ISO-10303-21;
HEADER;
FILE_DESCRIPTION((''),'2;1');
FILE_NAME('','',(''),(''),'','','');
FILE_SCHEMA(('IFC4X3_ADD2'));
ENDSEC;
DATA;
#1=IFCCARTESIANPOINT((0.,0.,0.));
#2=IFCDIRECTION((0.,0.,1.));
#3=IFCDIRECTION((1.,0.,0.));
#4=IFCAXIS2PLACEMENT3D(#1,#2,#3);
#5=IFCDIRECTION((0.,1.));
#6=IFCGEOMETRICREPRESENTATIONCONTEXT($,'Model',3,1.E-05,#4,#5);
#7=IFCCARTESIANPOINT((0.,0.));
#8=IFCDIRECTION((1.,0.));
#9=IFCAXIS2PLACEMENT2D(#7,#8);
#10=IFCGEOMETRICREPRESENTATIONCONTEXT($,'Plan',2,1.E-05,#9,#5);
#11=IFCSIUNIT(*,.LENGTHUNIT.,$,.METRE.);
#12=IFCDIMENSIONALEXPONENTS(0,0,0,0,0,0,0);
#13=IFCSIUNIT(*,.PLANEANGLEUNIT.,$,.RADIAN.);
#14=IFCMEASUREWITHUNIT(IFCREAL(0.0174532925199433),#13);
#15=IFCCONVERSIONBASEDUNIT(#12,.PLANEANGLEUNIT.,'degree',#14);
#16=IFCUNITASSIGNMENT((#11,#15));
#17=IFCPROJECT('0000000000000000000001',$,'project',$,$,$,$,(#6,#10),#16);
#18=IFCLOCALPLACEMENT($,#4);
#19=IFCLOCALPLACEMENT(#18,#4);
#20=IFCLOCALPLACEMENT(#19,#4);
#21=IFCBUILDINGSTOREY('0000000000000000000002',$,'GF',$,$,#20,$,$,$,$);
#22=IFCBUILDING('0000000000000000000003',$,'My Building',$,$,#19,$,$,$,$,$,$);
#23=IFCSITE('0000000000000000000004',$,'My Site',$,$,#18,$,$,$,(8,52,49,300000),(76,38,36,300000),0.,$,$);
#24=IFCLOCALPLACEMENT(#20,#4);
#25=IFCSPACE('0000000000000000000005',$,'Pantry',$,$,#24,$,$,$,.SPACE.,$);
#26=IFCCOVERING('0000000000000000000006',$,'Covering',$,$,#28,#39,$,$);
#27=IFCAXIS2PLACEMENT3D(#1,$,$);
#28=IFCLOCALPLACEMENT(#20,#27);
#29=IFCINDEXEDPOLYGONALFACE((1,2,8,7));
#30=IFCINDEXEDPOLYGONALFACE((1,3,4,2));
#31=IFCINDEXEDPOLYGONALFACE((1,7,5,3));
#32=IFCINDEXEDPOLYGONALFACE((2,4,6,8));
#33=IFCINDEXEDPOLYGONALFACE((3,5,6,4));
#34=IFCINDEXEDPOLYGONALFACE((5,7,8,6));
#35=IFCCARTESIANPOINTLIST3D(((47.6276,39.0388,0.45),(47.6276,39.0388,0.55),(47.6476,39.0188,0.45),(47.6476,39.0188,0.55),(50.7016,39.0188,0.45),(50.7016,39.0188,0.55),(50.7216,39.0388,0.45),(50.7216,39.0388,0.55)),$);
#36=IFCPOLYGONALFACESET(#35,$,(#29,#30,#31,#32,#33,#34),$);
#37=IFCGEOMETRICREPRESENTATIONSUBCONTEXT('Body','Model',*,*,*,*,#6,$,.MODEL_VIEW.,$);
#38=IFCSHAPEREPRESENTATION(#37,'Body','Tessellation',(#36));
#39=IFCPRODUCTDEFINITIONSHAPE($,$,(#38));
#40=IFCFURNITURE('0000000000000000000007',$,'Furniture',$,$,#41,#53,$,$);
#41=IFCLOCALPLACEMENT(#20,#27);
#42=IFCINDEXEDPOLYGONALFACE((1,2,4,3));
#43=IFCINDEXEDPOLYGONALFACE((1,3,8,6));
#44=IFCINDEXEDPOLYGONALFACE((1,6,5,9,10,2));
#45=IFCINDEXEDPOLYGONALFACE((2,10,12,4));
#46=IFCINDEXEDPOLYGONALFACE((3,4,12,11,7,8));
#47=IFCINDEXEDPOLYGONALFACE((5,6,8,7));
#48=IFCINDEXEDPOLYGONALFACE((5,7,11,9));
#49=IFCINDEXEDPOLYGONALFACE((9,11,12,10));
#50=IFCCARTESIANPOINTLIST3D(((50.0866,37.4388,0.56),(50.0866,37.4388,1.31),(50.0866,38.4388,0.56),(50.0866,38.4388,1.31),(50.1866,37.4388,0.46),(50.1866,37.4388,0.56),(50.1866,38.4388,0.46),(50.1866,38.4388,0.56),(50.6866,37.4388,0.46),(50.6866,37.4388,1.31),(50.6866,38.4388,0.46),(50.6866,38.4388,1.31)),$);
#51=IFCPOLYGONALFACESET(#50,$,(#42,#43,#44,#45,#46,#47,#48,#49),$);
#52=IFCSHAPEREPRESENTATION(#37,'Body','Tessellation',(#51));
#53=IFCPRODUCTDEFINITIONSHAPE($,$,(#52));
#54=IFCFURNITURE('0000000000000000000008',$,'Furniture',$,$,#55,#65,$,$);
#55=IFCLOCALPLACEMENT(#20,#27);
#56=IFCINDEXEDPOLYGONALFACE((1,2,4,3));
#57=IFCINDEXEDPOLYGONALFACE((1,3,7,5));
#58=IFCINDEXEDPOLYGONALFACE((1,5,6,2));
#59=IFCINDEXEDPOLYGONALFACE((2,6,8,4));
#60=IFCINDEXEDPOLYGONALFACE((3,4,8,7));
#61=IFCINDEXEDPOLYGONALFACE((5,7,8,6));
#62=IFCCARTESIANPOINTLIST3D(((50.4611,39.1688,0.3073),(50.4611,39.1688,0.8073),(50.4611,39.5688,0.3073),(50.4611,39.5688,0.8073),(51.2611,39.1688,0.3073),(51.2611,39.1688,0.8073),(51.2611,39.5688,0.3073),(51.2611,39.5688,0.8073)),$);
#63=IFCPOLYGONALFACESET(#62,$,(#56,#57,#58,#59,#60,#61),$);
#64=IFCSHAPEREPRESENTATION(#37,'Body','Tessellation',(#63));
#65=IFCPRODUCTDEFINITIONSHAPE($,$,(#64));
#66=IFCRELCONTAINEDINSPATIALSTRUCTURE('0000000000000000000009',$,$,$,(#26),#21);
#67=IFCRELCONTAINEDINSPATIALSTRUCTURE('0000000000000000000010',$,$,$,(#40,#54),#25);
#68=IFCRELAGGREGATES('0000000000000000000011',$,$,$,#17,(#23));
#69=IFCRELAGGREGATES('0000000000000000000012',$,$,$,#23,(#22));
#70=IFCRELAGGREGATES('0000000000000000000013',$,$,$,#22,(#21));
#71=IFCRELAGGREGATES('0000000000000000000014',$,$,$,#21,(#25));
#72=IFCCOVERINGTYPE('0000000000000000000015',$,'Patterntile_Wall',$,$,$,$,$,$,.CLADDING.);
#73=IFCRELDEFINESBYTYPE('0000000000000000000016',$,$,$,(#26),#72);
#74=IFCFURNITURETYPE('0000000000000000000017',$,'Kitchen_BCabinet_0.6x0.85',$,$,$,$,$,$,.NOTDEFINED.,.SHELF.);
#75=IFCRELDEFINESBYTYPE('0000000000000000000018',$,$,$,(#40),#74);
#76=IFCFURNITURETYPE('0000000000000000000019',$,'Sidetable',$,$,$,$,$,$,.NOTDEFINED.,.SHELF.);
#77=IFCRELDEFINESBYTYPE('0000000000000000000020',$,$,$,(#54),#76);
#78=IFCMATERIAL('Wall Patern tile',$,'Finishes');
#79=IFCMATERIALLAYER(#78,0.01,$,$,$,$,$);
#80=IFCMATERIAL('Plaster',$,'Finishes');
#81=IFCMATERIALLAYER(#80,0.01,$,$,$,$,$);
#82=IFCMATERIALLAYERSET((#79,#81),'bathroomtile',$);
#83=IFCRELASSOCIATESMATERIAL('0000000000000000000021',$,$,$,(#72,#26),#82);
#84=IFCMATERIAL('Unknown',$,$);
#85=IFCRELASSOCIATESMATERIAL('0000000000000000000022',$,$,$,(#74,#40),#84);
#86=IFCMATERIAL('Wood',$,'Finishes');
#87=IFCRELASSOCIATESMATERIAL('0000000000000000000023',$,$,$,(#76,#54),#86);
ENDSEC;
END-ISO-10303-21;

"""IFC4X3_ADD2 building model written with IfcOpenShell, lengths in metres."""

from ifc_helpers import new_model, entity, si_unit, converted_unit, direction, frame, origin_with_axes, origin_2d_with_axis, place, context, subcontext, project, spatial, line, indexed_curve, rectangle, outline, extrude, material, layer, layer_set, layer_usage, material_profile, profile_set, profile_usage, type_object, element, save


model = new_model("IFC4X3_ADD2")

# Units and contexts
model_context = context("Model", 3, precision=1e-05, world=origin_with_axes(), true_north=direction((0.0, 1.0)))
plan_context = context("Plan", 2, precision=1e-05, world=origin_2d_with_axis(), true_north=direction((0.0, 1.0)))
body_context_1 = subcontext(model_context, "Body", "Model", "MODEL_VIEW")
ifc_project = project(units=[si_unit("LENGTHUNIT", "METRE"), converted_unit("PLANEANGLEUNIT", "degree", entity("IfcReal", 0.0174532925199433), si_unit("PLANEANGLEUNIT", "RADIAN"), dimensions=[0, 0, 0, 0, 0, 0, 0])], contexts=[model_context, plan_context])

# Site, building, storey
site_placement = place(None, origin_with_axes())
site = spatial("IfcSite", under=ifc_project, at=site_placement, Name="My Site", RefLatitude=(8, 52, 49, 300000), RefLongitude=(76, 38, 36, 300000), RefElevation=0.0)
building_placement = place(site_placement, origin_with_axes())
building = spatial("IfcBuilding", under=site, at=building_placement, Name="My Building")
storey_placement = place(building_placement, origin_with_axes())
storey = spatial("IfcBuildingStorey", under=building, at=storey_placement, Name="GF")

# Shared definitions
ifc_material_1 = material(Name="Unknown")

# Covering
ifc_material_2 = material(Name="Wall Patern tile", Category="Finishes")
ifc_layer_1 = layer(ifc_material_2, 0.01)
ifc_material_3 = material(Name="Plaster", Category="Finishes")
ifc_layer_2 = layer(ifc_material_3, 0.01)
ifc_layer_set_1 = layer_set([ifc_layer_1, ifc_layer_2], Name="bathroomtile")
covering_type_1 = type_object("IfcCoveringType", Name="Patterntile_Wall", PredefinedType="CLADDING", material=ifc_layer_set_1)
ifc_layer_usage_1 = layer_usage(ifc_layer_set_1, "AXIS2", "NEGATIVE", 0.0)
covering_1_placement = place(storey_placement, frame((50.7016, 39.0188, 0.45), z_axis=(0.0, 0.0, 1.0), x_axis=(-1.0, 0.0, 0.0)))
element("IfcCovering", 1, at=covering_1_placement, inside=storey, type_object=covering_type_1, material=ifc_layer_usage_1, Name="Covering", context=body_context_1, shape_type="SweptSolid", body=[
    extrude(outline(indexed_curve([(-0.02, -0.02), (0.0, 0.0), (3.0541, 0.0), (3.0741, -0.02)], segments=[line(1, 2, 3, 4, 1)])), origin_with_axes(), (0.0, 0.0, 1.0), 0.1),
])

# Shared definitions
space_placement = place(storey_placement, origin_with_axes())
space = spatial("IfcSpace", under=storey, at=space_placement, Name="Pantry", PredefinedType="SPACE")

# Furniture
ifc_material_profile_1 = material_profile(ifc_material_1, outline(indexed_curve([(0.5, 0.0), (0.0, 0.0), (0.0, 0.85), (0.6, 0.85), (0.6, 0.1), (0.5, 0.1), (0.5, 0.0)])))
ifc_profile_set_1 = profile_set([ifc_material_profile_1], Name="blank")
ifc_profile_usage_1 = profile_usage(ifc_profile_set_1, cardinal=5)
furniture_type_1 = type_object("IfcFurnitureType", Name="Kitchen_BCabinet_0.6x0.85", AssemblyPlace="NOTDEFINED", PredefinedType="SHELF", material=ifc_profile_set_1)
furniture_1_placement = place(space_placement, frame((50.6866, 37.4388, 0.46), z_axis=(0.0, 1.0, 0.0), x_axis=(-1.0, 0.0, 0.0)))
element("IfcFurniture", 2, at=furniture_1_placement, inside=space, type_object=furniture_type_1, material=ifc_profile_usage_1, Name="Furniture", context=body_context_1, shape_type="SweptSolid", body=[
    extrude(outline(indexed_curve([(0.5, 0.0), (0.0, 0.0), (0.0, 0.85), (0.6, 0.85), (0.6, 0.1), (0.5, 0.1), (0.5, 0.0)])), origin_with_axes(), (0.0, 0.0, 1.0), 1.0),
])
ifc_material_4 = material(Name="Wood", Category="Finishes")
ifc_material_profile_2 = material_profile(ifc_material_4, rectangle(XDim=0.4, YDim=0.5))
ifc_profile_set_2 = profile_set([ifc_material_profile_2], Name="blank")
ifc_profile_usage_2 = profile_usage(ifc_profile_set_2)
furniture_type_2 = type_object("IfcFurnitureType", Name="Sidetable", AssemblyPlace="NOTDEFINED", PredefinedType="SHELF", material=ifc_profile_set_2)
furniture_2_placement = place(space_placement, frame((50.4611, 39.3688, 0.5573), z_axis=(1.0, 0.0, 0.0), x_axis=(0.0, 1.0, 0.0)))
element("IfcFurniture", 3, at=furniture_2_placement, inside=space, type_object=furniture_type_2, material=ifc_profile_usage_2, Name="Furniture", context=body_context_1, shape_type="SweptSolid", body=[
    extrude(rectangle(XDim=0.4, YDim=0.5), origin_with_axes(), (0.0, 0.0, 1.0), 0.8),
])

save(model, "model.ifc")
